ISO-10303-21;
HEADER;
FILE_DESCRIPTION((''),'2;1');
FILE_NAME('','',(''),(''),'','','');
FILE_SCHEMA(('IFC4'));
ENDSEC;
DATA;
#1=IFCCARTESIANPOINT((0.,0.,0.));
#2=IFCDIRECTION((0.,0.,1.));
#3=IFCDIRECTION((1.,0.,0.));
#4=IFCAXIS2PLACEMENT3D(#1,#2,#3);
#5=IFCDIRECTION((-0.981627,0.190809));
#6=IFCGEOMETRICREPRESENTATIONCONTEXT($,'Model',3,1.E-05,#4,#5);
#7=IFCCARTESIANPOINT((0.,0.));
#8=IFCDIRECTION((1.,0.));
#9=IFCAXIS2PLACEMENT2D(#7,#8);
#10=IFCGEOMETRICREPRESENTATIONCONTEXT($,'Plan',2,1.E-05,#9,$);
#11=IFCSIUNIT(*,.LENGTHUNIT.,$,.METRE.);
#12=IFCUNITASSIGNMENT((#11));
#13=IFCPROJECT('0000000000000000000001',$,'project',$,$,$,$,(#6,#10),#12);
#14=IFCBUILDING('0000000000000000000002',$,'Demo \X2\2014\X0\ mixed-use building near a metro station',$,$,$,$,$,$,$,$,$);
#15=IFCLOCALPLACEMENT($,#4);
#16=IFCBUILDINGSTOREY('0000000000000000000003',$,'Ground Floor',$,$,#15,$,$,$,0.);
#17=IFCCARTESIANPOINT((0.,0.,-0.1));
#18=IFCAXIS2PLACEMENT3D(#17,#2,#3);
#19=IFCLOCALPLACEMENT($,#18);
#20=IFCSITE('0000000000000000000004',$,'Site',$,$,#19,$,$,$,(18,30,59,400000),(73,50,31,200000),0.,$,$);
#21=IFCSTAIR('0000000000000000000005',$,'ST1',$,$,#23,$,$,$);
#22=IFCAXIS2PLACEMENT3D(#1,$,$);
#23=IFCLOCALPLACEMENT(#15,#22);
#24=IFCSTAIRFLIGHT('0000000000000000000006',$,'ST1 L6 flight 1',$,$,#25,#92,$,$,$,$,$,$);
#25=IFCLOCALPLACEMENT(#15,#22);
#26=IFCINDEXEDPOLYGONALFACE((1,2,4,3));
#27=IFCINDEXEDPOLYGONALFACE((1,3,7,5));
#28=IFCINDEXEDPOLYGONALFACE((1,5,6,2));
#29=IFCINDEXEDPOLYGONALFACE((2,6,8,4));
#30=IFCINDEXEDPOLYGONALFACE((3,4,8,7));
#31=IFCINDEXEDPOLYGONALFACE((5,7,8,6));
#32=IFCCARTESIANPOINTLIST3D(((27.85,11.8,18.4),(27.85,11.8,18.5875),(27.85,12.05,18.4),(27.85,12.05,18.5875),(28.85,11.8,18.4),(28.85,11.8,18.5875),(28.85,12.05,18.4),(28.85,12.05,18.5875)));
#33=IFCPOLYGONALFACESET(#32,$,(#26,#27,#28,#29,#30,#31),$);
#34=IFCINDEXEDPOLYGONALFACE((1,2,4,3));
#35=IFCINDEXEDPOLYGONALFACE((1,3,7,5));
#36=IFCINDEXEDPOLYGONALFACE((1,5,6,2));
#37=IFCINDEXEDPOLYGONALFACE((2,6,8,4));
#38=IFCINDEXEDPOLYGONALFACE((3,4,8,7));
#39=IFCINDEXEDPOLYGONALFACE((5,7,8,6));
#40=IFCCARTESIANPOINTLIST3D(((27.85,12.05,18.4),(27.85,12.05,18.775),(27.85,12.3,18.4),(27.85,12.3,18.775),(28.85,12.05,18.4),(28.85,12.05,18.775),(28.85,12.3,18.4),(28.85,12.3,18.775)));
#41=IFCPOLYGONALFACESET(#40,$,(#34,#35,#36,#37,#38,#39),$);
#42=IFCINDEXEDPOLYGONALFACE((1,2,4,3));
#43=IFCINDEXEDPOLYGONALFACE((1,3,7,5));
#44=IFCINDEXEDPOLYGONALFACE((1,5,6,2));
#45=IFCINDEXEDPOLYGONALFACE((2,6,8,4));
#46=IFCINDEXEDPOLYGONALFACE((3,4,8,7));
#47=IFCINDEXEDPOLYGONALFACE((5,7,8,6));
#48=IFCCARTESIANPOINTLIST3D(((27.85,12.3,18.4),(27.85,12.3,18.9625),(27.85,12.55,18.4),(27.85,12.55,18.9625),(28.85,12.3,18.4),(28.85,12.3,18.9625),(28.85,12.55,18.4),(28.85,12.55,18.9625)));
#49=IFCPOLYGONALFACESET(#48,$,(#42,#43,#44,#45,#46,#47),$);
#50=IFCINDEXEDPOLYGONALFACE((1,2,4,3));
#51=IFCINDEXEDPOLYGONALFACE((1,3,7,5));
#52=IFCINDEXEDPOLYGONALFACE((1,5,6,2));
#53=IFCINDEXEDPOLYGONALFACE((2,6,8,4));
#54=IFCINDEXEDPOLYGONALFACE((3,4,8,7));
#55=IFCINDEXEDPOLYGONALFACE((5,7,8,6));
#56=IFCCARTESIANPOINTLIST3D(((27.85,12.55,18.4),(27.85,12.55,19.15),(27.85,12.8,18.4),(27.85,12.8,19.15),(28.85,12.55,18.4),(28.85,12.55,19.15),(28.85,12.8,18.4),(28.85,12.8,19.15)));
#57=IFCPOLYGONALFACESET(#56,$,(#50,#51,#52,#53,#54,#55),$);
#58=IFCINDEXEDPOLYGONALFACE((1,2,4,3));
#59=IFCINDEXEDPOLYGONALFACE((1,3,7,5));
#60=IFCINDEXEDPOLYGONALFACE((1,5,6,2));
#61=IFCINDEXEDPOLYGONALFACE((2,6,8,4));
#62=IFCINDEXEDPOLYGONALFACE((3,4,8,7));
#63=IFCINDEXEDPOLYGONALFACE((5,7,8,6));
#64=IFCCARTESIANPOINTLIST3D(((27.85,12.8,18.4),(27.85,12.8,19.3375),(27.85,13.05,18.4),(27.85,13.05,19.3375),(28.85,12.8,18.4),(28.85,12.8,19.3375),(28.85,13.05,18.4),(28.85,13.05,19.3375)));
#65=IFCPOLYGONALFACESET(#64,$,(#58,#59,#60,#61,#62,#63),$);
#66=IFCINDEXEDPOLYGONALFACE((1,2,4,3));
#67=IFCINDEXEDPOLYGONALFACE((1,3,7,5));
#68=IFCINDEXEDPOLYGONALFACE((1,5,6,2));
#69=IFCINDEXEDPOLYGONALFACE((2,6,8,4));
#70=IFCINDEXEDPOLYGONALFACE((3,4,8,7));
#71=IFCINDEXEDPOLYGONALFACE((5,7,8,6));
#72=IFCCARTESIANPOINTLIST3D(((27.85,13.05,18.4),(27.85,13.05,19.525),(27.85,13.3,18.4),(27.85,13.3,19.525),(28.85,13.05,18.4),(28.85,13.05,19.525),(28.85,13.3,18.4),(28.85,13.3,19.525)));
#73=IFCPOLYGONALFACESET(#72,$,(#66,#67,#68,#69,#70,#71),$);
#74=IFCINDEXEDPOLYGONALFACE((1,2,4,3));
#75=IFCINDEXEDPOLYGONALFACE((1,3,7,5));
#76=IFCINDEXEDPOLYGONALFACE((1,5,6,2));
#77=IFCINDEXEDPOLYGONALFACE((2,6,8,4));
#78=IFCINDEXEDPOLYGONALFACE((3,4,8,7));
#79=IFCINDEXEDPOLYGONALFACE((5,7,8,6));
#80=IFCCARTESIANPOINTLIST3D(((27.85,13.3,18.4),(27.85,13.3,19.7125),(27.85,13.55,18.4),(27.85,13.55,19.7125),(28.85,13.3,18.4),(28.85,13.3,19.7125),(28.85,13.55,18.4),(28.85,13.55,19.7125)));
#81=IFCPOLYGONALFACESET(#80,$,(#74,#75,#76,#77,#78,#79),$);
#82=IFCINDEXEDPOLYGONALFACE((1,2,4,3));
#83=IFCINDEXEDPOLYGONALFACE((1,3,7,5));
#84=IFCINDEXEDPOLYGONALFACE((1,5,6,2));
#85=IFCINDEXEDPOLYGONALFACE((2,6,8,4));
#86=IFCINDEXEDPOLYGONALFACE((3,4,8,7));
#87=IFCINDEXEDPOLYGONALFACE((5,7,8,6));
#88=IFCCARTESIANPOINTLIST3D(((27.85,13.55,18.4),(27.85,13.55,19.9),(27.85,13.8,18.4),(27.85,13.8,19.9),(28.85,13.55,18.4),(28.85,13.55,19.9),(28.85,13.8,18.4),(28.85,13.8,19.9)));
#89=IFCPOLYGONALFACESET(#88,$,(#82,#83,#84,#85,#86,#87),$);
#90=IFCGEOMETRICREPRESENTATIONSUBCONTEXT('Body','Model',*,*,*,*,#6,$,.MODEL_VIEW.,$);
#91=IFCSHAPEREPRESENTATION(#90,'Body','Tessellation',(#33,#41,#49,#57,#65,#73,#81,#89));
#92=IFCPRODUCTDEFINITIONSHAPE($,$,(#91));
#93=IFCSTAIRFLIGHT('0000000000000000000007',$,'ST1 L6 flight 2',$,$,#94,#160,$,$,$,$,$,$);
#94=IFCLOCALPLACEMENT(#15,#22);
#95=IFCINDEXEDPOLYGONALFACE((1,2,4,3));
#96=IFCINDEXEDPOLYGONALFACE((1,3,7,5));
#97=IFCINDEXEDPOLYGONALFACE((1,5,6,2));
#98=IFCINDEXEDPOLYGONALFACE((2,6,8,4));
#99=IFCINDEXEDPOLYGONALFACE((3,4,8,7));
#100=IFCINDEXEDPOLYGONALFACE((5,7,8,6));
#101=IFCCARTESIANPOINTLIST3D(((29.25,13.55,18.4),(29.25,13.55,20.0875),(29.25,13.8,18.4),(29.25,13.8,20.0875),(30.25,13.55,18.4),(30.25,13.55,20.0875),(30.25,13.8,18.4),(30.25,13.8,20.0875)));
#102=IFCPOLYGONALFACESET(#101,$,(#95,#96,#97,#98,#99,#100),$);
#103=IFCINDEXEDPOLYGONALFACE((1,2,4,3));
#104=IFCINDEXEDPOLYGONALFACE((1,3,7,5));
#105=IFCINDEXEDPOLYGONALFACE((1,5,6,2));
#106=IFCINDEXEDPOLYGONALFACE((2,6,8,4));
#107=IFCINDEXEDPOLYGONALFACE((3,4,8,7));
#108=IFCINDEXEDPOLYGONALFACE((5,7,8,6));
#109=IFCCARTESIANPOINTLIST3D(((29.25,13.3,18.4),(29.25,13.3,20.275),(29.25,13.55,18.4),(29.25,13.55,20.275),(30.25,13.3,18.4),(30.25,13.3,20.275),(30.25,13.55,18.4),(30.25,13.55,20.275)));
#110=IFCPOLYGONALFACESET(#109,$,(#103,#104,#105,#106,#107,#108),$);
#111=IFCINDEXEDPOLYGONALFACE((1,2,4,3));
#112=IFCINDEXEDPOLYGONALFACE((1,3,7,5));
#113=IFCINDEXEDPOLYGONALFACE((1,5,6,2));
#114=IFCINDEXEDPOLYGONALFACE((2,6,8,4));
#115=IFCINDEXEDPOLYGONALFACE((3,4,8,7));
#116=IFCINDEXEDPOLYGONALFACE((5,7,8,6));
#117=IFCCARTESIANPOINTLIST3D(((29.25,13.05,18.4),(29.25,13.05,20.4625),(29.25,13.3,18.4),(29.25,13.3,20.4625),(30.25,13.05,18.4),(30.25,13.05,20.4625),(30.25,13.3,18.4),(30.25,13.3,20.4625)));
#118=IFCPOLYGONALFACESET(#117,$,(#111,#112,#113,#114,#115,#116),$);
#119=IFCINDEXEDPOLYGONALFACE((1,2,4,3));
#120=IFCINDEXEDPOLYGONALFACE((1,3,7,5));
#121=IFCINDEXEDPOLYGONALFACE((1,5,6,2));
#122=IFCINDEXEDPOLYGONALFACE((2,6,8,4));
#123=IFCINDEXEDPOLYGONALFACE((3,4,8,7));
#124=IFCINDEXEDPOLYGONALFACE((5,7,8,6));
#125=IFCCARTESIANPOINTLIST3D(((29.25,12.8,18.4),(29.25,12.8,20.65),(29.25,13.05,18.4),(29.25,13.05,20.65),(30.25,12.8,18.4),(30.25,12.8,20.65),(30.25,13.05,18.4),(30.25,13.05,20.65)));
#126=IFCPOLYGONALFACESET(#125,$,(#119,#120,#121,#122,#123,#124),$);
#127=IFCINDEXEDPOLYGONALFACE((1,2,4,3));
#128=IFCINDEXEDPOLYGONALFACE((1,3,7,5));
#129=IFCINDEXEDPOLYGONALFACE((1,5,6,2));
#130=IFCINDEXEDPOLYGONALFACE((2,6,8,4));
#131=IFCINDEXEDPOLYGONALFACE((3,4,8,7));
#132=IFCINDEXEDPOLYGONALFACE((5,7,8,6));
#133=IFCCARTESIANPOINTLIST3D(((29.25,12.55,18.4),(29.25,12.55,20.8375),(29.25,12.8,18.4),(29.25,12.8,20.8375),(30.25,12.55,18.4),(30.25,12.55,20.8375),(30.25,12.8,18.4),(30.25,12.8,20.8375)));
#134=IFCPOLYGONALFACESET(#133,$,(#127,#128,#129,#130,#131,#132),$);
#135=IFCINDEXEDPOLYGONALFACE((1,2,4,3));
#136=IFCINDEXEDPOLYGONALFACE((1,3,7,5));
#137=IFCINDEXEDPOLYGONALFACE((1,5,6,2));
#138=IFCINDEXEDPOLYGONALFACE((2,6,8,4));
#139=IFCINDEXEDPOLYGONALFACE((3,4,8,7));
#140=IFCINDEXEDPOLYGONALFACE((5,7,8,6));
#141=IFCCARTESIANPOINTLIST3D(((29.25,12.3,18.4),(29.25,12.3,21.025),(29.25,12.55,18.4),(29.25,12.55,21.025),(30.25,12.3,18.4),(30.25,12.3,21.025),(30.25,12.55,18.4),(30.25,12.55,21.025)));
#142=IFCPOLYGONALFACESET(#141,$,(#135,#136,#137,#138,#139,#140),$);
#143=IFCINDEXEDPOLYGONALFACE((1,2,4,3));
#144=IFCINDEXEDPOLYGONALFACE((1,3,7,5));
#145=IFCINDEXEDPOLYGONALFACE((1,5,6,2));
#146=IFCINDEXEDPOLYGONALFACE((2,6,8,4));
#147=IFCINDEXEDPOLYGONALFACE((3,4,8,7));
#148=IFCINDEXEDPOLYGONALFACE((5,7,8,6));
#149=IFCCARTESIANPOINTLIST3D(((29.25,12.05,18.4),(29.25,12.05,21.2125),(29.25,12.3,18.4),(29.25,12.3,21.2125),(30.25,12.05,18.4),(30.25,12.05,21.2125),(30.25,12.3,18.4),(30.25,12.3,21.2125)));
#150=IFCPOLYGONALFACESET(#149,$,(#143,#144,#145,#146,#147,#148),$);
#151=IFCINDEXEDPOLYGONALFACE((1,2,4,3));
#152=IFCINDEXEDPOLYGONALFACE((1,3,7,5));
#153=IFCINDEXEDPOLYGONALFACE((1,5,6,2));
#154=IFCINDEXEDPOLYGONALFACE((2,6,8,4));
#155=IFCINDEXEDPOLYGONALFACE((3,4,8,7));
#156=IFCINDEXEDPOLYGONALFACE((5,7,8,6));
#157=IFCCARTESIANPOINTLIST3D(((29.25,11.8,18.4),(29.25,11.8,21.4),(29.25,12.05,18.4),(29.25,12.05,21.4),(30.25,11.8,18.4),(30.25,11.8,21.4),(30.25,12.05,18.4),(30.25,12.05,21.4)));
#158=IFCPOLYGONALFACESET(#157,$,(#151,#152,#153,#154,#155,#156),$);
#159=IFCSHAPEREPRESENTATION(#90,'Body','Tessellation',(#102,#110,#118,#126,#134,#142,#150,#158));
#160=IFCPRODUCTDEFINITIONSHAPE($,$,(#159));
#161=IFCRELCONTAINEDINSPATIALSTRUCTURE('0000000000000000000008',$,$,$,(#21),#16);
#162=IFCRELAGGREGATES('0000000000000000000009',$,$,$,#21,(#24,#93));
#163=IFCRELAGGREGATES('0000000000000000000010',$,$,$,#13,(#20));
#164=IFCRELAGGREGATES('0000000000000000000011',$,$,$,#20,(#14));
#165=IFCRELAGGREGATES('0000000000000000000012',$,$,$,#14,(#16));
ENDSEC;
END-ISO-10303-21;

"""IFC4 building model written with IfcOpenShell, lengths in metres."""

from ifc_helpers import new_model, si_unit, direction, frame, origin_with_axes, origin_2d_with_axis, place, context, subcontext, project, spatial, line, indexed_curve, outline, extrude, element, aggregate, save


model = new_model("IFC4")

# Units and contexts
model_context = context("Model", 3, precision=1e-05, world=origin_with_axes(), true_north=direction((-0.981627, 0.190809)))
plan_context = context("Plan", 2, precision=1e-05, world=origin_2d_with_axis())
body_context = subcontext(model_context, "Body", "Model", "MODEL_VIEW")
ifc_project = project(units=[si_unit("LENGTHUNIT", "METRE")], contexts=[model_context, plan_context])

# Site, building, storey
site_placement = place(None, frame((0.0, 0.0, -0.1), z_axis=(0.0, 0.0, 1.0), x_axis=(1.0, 0.0, 0.0)))
site = spatial("IfcSite", under=ifc_project, at=site_placement, Name="Site", RefLatitude=(18, 30, 59, 400000), RefLongitude=(73, 50, 31, 200000), RefElevation=0.0)
building = spatial("IfcBuilding", under=site, Name="Demo — mixed-use building near a metro station")
storey_placement = place(None, origin_with_axes())
storey = spatial("IfcBuildingStorey", under=building, at=storey_placement, Name="Ground Floor", Elevation=0.0)

# Stair, stair flights
stair = element("IfcStair", 1, inside=storey, Name="ST1")
stair_flight_1_placement = place(None, origin_with_axes())
stair_flight_1 = element("IfcStairFlight", 2, at=stair_flight_1_placement, Name="ST1 L6 flight 1", context=body_context, shape_type="SweptSolid", body=[
    extrude(outline(indexed_curve([(27.85, 11.8), (28.85, 11.8), (28.85, 12.05), (27.85, 12.05)], segments=[line(1, 2, 3, 4, 1)])), frame((0.0, 0.0, 18.4), z_axis=(0.0, 0.0, 1.0), x_axis=(1.0, 0.0, 0.0)), (0.0, 0.0, 1.0), 0.1875),
    extrude(outline(indexed_curve([(27.85, 12.05), (28.85, 12.05), (28.85, 12.3), (27.85, 12.3)], segments=[line(1, 2, 3, 4, 1)])), frame((0.0, 0.0, 18.4), z_axis=(0.0, 0.0, 1.0), x_axis=(1.0, 0.0, 0.0)), (0.0, 0.0, 1.0), 0.375),
    extrude(outline(indexed_curve([(27.85, 12.3), (28.85, 12.3), (28.85, 12.55), (27.85, 12.55)], segments=[line(1, 2, 3, 4, 1)])), frame((0.0, 0.0, 18.4), z_axis=(0.0, 0.0, 1.0), x_axis=(1.0, 0.0, 0.0)), (0.0, 0.0, 1.0), 0.5625),
    extrude(outline(indexed_curve([(27.85, 12.55), (28.85, 12.55), (28.85, 12.8), (27.85, 12.8)], segments=[line(1, 2, 3, 4, 1)])), frame((0.0, 0.0, 18.4), z_axis=(0.0, 0.0, 1.0), x_axis=(1.0, 0.0, 0.0)), (0.0, 0.0, 1.0), 0.75),
    extrude(outline(indexed_curve([(27.85, 12.8), (28.85, 12.8), (28.85, 13.05), (27.85, 13.05)], segments=[line(1, 2, 3, 4, 1)])), frame((0.0, 0.0, 18.4), z_axis=(0.0, 0.0, 1.0), x_axis=(1.0, 0.0, 0.0)), (0.0, 0.0, 1.0), 0.9375),
    extrude(outline(indexed_curve([(27.85, 13.05), (28.85, 13.05), (28.85, 13.3), (27.85, 13.3)], segments=[line(1, 2, 3, 4, 1)])), frame((0.0, 0.0, 18.4), z_axis=(0.0, 0.0, 1.0), x_axis=(1.0, 0.0, 0.0)), (0.0, 0.0, 1.0), 1.125),
    extrude(outline(indexed_curve([(27.85, 13.3), (28.85, 13.3), (28.85, 13.55), (27.85, 13.55)], segments=[line(1, 2, 3, 4, 1)])), frame((0.0, 0.0, 18.4), z_axis=(0.0, 0.0, 1.0), x_axis=(1.0, 0.0, 0.0)), (0.0, 0.0, 1.0), 1.3125),
    extrude(outline(indexed_curve([(27.85, 13.55), (28.85, 13.55), (28.85, 13.8), (27.85, 13.8)], segments=[line(1, 2, 3, 4, 1)])), frame((0.0, 0.0, 18.4), z_axis=(0.0, 0.0, 1.0), x_axis=(1.0, 0.0, 0.0)), (0.0, 0.0, 1.0), 1.5),
])
stair_flight_2_placement = place(None, origin_with_axes())
stair_flight_2 = element("IfcStairFlight", 3, at=stair_flight_2_placement, Name="ST1 L6 flight 2", context=body_context, shape_type="SweptSolid", body=[
    extrude(outline(indexed_curve([(29.25, 13.55), (30.25, 13.55), (30.25, 13.8), (29.25, 13.8)], segments=[line(1, 2, 3, 4, 1)])), frame((0.0, 0.0, 18.4), z_axis=(0.0, 0.0, 1.0), x_axis=(1.0, 0.0, 0.0)), (0.0, 0.0, 1.0), 1.6875),
    extrude(outline(indexed_curve([(29.25, 13.3), (30.25, 13.3), (30.25, 13.55), (29.25, 13.55)], segments=[line(1, 2, 3, 4, 1)])), frame((0.0, 0.0, 18.4), z_axis=(0.0, 0.0, 1.0), x_axis=(1.0, 0.0, 0.0)), (0.0, 0.0, 1.0), 1.875),
    extrude(outline(indexed_curve([(29.25, 13.05), (30.25, 13.05), (30.25, 13.3), (29.25, 13.3)], segments=[line(1, 2, 3, 4, 1)])), frame((0.0, 0.0, 18.4), z_axis=(0.0, 0.0, 1.0), x_axis=(1.0, 0.0, 0.0)), (0.0, 0.0, 1.0), 2.0625),
    extrude(outline(indexed_curve([(29.25, 12.8), (30.25, 12.8), (30.25, 13.05), (29.25, 13.05)], segments=[line(1, 2, 3, 4, 1)])), frame((0.0, 0.0, 18.4), z_axis=(0.0, 0.0, 1.0), x_axis=(1.0, 0.0, 0.0)), (0.0, 0.0, 1.0), 2.25),
    extrude(outline(indexed_curve([(29.25, 12.55), (30.25, 12.55), (30.25, 12.8), (29.25, 12.8)], segments=[line(1, 2, 3, 4, 1)])), frame((0.0, 0.0, 18.4), z_axis=(0.0, 0.0, 1.0), x_axis=(1.0, 0.0, 0.0)), (0.0, 0.0, 1.0), 2.4375),
    extrude(outline(indexed_curve([(29.25, 12.3), (30.25, 12.3), (30.25, 12.55), (29.25, 12.55)], segments=[line(1, 2, 3, 4, 1)])), frame((0.0, 0.0, 18.4), z_axis=(0.0, 0.0, 1.0), x_axis=(1.0, 0.0, 0.0)), (0.0, 0.0, 1.0), 2.625),
    extrude(outline(indexed_curve([(29.25, 12.05), (30.25, 12.05), (30.25, 12.3), (29.25, 12.3)], segments=[line(1, 2, 3, 4, 1)])), frame((0.0, 0.0, 18.4), z_axis=(0.0, 0.0, 1.0), x_axis=(1.0, 0.0, 0.0)), (0.0, 0.0, 1.0), 2.8125),
    extrude(outline(indexed_curve([(29.25, 11.8), (30.25, 11.8), (30.25, 12.05), (29.25, 12.05)], segments=[line(1, 2, 3, 4, 1)])), frame((0.0, 0.0, 18.4), z_axis=(0.0, 0.0, 1.0), x_axis=(1.0, 0.0, 0.0)), (0.0, 0.0, 1.0), 3.0),
])
aggregate(stair, [stair_flight_1, stair_flight_2])

save(model, "model.ifc")
